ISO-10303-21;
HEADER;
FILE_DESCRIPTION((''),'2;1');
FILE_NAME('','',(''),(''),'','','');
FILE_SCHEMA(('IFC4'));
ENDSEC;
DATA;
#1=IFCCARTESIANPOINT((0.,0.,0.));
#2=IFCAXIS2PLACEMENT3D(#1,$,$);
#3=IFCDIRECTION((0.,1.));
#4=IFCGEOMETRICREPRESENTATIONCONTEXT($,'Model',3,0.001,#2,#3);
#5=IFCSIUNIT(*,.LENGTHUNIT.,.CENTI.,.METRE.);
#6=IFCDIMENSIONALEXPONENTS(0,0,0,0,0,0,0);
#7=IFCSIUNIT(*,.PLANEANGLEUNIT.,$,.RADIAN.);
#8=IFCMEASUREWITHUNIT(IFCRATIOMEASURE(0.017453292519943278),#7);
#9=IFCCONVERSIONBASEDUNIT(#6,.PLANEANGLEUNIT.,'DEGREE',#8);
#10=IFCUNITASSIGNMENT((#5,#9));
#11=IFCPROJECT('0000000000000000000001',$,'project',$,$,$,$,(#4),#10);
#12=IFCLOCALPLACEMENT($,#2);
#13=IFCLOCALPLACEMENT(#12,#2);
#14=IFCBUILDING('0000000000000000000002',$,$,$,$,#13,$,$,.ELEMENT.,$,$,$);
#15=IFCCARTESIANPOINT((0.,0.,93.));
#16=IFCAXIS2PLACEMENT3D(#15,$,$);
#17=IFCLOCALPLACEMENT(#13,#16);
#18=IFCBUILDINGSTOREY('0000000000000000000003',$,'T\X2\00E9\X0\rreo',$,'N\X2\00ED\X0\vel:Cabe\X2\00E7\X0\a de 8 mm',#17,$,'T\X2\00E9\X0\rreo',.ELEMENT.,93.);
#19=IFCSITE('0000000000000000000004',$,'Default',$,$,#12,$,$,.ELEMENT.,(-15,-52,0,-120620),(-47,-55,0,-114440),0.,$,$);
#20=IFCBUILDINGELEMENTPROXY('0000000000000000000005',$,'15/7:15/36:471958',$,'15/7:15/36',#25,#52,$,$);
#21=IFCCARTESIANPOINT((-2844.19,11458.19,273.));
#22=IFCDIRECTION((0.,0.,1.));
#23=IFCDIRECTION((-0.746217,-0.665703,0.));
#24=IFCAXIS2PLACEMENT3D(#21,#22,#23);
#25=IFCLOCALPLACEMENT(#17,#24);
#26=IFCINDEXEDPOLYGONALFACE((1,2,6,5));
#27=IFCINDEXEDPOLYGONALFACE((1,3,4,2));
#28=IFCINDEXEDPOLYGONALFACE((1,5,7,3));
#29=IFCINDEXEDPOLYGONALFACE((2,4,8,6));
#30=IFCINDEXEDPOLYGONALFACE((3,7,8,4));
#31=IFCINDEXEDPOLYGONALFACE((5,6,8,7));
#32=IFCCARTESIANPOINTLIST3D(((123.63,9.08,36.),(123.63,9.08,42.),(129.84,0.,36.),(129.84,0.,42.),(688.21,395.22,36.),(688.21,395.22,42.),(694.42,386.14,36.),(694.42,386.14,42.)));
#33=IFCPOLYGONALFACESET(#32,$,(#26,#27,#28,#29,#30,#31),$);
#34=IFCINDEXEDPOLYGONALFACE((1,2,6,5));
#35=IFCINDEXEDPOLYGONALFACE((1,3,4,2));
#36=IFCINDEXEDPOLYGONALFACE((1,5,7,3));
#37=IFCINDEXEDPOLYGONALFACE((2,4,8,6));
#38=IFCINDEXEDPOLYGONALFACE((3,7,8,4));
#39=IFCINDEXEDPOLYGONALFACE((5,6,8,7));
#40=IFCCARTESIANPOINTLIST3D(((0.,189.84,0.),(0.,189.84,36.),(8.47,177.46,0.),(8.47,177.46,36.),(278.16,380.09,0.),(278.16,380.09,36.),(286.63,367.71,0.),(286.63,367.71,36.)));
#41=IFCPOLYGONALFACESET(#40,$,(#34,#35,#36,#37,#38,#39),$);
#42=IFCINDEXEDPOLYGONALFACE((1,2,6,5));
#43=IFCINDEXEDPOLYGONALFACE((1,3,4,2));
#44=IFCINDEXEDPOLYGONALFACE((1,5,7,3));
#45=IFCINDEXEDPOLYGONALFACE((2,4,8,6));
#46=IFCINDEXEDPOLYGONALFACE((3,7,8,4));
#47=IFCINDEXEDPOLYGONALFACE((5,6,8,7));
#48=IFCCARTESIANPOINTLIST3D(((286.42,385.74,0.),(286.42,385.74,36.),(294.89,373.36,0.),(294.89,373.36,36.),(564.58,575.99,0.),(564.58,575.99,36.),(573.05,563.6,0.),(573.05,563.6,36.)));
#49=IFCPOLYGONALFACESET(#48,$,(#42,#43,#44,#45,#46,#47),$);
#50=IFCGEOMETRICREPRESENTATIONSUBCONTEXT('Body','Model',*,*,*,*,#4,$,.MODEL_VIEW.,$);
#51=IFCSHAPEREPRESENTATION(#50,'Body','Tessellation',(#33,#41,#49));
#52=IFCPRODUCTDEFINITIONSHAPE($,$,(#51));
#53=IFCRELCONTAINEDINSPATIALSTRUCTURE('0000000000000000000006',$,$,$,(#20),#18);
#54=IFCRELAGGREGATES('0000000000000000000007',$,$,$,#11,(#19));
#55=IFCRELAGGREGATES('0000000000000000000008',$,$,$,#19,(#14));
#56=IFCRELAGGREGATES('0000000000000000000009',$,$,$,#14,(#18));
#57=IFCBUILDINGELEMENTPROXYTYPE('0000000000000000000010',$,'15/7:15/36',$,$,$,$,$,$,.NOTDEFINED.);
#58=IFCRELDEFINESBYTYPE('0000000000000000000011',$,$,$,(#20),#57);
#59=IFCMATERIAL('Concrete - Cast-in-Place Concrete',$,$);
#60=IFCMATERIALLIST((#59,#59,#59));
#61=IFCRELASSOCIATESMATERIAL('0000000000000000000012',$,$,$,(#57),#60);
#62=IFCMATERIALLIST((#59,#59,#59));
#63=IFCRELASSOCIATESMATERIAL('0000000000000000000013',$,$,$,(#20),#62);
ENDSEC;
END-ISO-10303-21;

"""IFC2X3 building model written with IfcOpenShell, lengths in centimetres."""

from ifc_helpers import new_model, entity, si_unit, converted_unit, direction, frame, frame_2d, origin, place, context, subcontext, project, spatial, rectangle, extrude, source, transform, mapped, material, material_list, type_object, type_shapes, element, save


model = new_model("IFC2X3")

# Units and contexts
model_context = context("Model", 3, precision=0.001, world=origin(), true_north=direction((0.0, 1.0)))
body_context = subcontext(model_context, "Body", "Model", "MODEL_VIEW")
ifc_project = project(units=[si_unit("LENGTHUNIT", "METRE", prefix="CENTI"), converted_unit("PLANEANGLEUNIT", "DEGREE", entity("IfcRatioMeasure", 0.017453292519943278), si_unit("PLANEANGLEUNIT", "RADIAN"), dimensions=[0, 0, 0, 0, 0, 0, 0])], contexts=[model_context])

# Site, building, storey
site_placement = place(None, origin())
site = spatial("IfcSite", under=ifc_project, at=site_placement, Name="Default", CompositionType="ELEMENT", RefLatitude=(-15, -52, 0, -120620), RefLongitude=(-47, -55, 0, -114440), RefElevation=0.0)
building_placement = place(site_placement, origin())
building = spatial("IfcBuilding", under=site, at=building_placement, CompositionType="ELEMENT")
storey_placement = place(building_placement, frame((0.0, 0.0, 93.0)))
storey = spatial("IfcBuildingStorey", under=building, at=storey_placement, Name="Térreo", ObjectType="Nível:Cabeça de 8 mm", LongName="Térreo", CompositionType="ELEMENT", Elevation=93.0)

# Building element proxy
ifc_material_1 = material(Name="Concrete - Cast-in-Place Concrete")
ifc_material_list_1 = material_list([ifc_material_1, ifc_material_1, ifc_material_1])
ifc_material_list_2 = material_list([ifc_material_1, ifc_material_1, ifc_material_1])
building_element_proxy_type_1 = type_object("IfcBuildingElementProxyType", Name="15/7:15/36", PredefinedType="NOTDEFINED", material=ifc_material_list_2)
shared_shape_1 = source(origin(), body_context, "Body", "SweptSolid", [
    extrude(rectangle(XDim=11.0, YDim=684.0, at=frame_2d((0.0, 0.0), x_axis=(1.0, 0.0))), frame((409.03, 197.61, 36.0), z_axis=(0.0, 0.0, 1.0), x_axis=(-0.564535, 0.825409, 0.0)), (0.0, 0.0, 1.0), 6.0),
    extrude(rectangle(XDim=337.0, YDim=15.0, at=frame_2d((0.0, 0.0), x_axis=(1.0, 0.0))), frame((143.32, 278.78, 0.0), z_axis=(0.0, 0.0, 1.0), x_axis=(0.825409, 0.564535, 0.0)), (0.0, 0.0, 1.0), 36.0),
    extrude(rectangle(XDim=337.0, YDim=15.0, at=frame_2d((0.0, 0.0), x_axis=(1.0, 0.0))), frame((429.73, 474.67, 0.0), z_axis=(0.0, 0.0, 1.0), x_axis=(0.825409, 0.564535, 0.0)), (0.0, 0.0, 1.0), 36.0),
])
type_shapes(building_element_proxy_type_1, [shared_shape_1])
proxy_1_placement = place(storey_placement, frame((-2844.19, 11458.19, 273.0), z_axis=(0.0, 0.0, 1.0), x_axis=(-0.746217, -0.665703, 0.0)))
element("IfcBuildingElementProxy", 1, at=proxy_1_placement, inside=storey, type_object=building_element_proxy_type_1, material=ifc_material_list_1, Name="15/7:15/36:471958", ObjectType="15/7:15/36", context=body_context, shape_type="MappedRepresentation", body=[
    mapped(shared_shape_1, transform((0.0, 0.0, 0.0), scale=1.0)),
])

save(model, "model.ifc")
